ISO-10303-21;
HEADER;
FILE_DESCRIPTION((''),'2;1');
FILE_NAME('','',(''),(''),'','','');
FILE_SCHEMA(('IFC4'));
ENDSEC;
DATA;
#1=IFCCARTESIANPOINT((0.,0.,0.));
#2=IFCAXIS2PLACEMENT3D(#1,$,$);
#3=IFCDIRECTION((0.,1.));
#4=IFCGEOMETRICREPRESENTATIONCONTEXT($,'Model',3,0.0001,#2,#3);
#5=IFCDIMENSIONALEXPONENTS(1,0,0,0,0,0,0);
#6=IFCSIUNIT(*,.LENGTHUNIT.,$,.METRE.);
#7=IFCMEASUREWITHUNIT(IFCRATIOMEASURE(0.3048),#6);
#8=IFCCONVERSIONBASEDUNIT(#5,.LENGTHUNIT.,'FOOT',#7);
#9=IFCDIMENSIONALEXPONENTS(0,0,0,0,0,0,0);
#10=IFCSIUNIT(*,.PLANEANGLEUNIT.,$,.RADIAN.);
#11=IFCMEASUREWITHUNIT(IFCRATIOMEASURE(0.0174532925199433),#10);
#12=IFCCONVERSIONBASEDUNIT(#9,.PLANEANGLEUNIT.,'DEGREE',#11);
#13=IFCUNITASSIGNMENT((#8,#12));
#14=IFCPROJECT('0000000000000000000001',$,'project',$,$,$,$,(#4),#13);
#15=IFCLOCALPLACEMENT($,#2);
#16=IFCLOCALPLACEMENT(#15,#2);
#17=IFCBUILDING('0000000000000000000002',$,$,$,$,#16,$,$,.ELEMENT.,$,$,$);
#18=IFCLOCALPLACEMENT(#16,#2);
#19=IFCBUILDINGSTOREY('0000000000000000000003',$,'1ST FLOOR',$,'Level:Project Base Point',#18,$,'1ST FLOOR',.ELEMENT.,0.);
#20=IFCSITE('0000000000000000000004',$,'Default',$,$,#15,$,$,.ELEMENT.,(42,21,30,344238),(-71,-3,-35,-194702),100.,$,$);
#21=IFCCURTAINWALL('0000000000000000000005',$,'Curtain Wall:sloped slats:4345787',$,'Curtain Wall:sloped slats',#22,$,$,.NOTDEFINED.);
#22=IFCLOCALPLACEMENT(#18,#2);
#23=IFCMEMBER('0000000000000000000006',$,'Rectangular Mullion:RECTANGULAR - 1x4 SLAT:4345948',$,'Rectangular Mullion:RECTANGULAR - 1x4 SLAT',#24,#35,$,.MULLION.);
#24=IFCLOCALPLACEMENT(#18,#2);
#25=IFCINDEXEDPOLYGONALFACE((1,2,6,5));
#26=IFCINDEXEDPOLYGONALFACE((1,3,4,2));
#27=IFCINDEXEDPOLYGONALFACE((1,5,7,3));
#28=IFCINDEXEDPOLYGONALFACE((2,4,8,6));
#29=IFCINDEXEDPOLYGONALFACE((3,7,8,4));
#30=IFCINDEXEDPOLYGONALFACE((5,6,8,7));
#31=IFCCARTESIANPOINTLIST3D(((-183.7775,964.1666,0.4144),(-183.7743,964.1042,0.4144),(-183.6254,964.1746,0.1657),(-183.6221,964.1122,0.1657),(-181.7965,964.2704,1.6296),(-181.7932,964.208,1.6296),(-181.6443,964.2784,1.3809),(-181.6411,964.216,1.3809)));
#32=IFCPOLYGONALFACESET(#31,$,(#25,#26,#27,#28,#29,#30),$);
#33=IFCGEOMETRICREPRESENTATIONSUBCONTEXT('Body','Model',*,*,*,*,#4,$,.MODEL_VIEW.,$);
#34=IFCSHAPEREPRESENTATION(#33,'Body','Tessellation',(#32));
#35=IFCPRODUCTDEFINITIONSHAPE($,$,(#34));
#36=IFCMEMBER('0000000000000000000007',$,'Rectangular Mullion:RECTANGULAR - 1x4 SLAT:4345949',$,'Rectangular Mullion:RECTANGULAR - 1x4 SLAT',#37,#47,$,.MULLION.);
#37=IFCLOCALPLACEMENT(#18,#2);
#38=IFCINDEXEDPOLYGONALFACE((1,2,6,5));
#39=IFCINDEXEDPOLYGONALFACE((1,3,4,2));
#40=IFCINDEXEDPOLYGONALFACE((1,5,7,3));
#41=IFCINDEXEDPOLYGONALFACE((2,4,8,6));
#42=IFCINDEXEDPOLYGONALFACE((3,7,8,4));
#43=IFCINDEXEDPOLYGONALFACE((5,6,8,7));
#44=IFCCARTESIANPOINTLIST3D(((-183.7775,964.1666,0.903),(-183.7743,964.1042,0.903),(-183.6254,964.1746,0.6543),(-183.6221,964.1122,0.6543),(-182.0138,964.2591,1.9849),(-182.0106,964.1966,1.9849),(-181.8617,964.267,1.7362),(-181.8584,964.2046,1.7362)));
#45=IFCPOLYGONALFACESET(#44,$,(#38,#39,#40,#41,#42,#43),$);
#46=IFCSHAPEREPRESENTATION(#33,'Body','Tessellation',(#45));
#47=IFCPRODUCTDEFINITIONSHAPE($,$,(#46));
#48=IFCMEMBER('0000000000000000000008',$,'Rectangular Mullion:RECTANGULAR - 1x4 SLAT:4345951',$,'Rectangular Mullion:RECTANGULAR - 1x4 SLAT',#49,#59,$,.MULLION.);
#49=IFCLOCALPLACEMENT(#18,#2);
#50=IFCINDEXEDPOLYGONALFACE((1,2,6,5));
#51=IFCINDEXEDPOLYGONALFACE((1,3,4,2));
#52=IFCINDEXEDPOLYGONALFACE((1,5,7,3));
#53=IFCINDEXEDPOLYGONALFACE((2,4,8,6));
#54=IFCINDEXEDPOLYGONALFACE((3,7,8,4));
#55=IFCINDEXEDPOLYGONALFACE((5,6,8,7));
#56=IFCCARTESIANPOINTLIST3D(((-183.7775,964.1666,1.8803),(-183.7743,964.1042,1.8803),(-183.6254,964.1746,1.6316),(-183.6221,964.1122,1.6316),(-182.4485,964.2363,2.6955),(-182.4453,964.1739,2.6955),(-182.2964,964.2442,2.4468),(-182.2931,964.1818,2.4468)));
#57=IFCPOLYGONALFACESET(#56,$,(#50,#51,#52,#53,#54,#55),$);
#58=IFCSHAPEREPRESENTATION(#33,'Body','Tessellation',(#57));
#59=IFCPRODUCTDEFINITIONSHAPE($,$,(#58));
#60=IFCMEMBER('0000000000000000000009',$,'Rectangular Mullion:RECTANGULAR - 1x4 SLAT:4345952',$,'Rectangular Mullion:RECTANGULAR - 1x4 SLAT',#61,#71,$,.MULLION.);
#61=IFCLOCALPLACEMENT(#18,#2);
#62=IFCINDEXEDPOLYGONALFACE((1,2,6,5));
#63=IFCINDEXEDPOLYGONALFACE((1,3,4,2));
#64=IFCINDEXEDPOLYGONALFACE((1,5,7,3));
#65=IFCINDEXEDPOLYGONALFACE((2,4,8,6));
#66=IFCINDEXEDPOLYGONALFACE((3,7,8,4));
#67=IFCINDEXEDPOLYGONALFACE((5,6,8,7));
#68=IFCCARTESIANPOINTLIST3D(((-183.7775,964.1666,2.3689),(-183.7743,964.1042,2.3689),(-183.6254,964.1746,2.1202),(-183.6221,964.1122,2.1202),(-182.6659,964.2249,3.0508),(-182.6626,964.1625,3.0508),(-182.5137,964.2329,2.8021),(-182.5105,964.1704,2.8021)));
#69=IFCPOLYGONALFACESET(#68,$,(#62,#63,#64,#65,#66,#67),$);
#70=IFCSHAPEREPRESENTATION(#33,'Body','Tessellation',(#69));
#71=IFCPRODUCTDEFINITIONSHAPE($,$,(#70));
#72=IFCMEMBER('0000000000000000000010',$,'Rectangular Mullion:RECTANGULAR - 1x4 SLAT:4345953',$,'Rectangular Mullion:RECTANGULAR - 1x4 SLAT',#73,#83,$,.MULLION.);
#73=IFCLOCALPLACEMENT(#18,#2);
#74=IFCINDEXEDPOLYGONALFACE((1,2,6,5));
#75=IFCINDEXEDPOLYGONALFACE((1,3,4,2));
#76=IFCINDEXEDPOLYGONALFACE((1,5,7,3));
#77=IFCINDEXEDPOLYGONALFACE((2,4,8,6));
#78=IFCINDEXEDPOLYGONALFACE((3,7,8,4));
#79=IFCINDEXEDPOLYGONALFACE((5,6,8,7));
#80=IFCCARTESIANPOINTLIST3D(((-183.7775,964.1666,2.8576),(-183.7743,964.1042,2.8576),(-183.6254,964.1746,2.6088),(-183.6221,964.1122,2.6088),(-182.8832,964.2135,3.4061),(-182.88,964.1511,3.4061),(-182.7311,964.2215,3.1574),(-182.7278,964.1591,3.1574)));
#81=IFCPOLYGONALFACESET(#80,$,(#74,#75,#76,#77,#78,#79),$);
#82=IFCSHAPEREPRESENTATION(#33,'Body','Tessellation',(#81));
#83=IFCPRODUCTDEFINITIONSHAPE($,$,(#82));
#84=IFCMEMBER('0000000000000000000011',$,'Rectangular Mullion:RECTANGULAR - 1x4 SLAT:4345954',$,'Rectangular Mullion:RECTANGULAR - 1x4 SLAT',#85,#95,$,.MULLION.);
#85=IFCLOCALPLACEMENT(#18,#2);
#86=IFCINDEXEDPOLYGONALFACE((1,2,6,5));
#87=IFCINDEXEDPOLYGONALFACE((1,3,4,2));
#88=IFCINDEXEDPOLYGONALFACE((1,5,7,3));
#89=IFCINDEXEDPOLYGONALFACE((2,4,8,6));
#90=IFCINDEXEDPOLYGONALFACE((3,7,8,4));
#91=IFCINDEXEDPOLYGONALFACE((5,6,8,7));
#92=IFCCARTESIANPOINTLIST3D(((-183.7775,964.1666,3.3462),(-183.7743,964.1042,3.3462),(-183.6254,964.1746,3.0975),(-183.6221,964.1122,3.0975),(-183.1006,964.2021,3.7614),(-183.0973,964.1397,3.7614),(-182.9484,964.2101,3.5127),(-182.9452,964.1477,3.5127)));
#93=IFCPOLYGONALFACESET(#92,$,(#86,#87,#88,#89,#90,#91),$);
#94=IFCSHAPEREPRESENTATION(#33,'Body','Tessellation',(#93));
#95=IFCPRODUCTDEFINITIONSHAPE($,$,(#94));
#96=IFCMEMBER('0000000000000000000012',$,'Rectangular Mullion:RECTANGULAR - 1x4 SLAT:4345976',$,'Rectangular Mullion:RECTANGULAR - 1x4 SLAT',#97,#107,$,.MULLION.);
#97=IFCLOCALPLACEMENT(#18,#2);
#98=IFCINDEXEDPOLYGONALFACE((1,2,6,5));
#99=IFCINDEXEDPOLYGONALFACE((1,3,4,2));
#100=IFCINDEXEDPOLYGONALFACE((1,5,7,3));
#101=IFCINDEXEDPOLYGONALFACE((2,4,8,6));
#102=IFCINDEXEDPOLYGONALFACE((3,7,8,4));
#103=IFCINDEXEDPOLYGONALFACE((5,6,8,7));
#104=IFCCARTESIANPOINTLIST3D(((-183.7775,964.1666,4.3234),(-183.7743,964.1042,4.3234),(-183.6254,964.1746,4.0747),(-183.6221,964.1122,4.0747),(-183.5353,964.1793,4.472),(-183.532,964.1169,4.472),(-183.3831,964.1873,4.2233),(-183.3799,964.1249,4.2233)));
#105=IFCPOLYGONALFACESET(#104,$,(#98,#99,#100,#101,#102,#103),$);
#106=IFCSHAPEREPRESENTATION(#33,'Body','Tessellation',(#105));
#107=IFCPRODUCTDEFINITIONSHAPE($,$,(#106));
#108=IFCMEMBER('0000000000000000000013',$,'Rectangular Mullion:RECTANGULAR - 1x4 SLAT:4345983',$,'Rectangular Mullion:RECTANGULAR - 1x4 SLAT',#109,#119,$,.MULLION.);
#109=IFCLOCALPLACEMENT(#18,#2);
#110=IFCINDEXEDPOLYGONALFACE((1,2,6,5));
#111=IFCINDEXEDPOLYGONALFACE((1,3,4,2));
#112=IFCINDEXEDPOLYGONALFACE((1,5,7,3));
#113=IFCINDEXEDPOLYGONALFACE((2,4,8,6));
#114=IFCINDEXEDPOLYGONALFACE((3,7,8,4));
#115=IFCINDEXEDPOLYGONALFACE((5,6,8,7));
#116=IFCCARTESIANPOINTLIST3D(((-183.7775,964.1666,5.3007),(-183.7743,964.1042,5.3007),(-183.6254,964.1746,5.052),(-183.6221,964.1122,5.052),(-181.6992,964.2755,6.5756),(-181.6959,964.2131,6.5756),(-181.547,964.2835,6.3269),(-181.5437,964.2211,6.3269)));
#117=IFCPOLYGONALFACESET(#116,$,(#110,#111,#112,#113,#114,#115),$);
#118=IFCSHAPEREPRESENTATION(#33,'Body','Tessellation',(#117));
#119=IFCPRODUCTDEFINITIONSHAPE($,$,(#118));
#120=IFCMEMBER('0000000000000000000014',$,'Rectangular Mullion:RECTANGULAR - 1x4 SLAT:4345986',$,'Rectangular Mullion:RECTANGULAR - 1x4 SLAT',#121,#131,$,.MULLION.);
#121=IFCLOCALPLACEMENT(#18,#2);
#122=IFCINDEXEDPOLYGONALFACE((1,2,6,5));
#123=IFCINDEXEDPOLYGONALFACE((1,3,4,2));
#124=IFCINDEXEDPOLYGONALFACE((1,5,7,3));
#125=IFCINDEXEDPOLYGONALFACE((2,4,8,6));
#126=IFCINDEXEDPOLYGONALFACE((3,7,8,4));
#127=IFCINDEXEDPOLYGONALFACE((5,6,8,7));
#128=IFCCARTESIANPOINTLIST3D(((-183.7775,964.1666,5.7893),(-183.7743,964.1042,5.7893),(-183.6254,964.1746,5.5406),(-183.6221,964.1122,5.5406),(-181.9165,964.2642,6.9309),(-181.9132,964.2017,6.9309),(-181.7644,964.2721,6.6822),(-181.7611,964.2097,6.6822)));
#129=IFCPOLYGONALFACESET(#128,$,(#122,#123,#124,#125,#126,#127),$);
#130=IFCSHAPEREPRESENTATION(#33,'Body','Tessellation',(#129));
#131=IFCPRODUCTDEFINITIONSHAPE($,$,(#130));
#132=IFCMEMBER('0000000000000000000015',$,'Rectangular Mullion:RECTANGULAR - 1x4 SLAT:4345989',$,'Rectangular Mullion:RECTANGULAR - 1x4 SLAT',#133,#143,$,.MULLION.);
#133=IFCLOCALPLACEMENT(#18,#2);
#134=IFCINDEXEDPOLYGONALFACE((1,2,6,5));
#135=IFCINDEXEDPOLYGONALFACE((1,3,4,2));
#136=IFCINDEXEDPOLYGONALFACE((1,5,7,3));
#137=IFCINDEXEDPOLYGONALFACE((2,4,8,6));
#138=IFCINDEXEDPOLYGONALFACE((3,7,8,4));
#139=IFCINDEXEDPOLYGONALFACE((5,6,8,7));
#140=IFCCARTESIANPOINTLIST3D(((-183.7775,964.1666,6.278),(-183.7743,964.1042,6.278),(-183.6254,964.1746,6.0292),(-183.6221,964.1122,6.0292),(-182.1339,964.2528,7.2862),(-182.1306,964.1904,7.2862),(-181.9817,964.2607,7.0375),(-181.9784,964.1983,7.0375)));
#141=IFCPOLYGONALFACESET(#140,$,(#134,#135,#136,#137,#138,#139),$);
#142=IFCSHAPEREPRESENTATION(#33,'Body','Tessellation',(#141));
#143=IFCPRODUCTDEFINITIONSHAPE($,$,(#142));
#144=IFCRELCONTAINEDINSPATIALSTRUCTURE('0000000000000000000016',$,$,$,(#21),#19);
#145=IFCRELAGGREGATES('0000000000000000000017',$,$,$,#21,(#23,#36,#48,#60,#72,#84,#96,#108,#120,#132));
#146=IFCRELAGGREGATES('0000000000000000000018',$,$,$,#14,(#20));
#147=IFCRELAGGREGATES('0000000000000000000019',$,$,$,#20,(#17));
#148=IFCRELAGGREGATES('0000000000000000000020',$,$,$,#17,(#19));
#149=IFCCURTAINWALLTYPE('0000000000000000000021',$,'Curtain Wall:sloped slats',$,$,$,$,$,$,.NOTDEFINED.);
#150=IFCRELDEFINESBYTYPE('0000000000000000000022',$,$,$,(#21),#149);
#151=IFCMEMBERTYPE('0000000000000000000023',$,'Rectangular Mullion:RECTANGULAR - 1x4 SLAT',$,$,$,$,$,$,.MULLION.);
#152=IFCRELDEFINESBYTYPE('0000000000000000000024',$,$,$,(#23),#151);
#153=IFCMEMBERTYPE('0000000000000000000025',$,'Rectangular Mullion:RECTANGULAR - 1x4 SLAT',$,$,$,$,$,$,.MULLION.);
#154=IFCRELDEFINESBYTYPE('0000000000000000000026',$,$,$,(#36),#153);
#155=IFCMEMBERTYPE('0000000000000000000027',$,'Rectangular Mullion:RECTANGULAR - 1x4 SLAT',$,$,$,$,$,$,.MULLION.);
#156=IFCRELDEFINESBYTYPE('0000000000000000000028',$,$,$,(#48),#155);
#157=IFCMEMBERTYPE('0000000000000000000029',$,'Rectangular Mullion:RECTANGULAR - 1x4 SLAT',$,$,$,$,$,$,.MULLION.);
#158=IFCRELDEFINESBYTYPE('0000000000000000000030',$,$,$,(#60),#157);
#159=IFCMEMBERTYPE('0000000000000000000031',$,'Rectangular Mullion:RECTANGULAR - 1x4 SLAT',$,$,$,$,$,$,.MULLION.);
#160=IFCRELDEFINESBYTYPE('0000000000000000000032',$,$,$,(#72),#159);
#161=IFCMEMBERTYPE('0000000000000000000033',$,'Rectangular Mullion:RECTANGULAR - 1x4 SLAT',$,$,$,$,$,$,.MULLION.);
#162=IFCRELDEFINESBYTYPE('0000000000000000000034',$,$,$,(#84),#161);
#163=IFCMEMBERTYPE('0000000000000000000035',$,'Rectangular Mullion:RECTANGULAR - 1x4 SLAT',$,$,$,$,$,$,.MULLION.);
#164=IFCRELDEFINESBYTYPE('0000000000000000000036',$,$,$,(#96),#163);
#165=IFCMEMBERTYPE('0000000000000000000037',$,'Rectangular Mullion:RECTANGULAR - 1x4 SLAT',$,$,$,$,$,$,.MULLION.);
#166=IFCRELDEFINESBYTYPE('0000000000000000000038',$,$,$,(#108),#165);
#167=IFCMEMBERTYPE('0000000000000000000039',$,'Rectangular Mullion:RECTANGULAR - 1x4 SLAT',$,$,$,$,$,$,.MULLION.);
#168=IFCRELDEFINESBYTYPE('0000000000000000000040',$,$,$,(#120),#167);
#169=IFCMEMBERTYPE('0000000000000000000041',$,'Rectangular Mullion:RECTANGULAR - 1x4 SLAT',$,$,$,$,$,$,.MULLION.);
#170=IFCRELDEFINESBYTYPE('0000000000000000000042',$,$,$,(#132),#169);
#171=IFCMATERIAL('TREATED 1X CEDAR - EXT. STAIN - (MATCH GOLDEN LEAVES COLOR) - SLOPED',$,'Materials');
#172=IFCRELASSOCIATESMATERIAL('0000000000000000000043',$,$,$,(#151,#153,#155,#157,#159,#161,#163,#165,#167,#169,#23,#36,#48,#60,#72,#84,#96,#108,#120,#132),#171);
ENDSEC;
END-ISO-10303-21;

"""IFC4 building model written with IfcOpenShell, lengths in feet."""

from ifc_helpers import new_model, entity, si_unit, converted_unit, direction, frame, frame_2d, origin, origin_2d_with_axis, place, context, subcontext, project, spatial, rectangle, extrude, source, transform, mapped, material, material_profile, profile_set, profile_usage, type_object, type_shapes, element, aggregate, save


model = new_model("IFC4")

# Units and contexts
model_context = context("Model", 3, precision=0.0001, world=origin(), true_north=direction((0.0, 1.0)))
body_context = subcontext(model_context, "Body", "Model", "MODEL_VIEW")
ifc_project = project(units=[converted_unit("LENGTHUNIT", "FOOT", entity("IfcRatioMeasure", 0.3048), si_unit("LENGTHUNIT", "METRE"), dimensions=[1, 0, 0, 0, 0, 0, 0]), converted_unit("PLANEANGLEUNIT", "DEGREE", entity("IfcRatioMeasure", 0.0174532925199433), si_unit("PLANEANGLEUNIT", "RADIAN"), dimensions=[0, 0, 0, 0, 0, 0, 0])], contexts=[model_context])

# Site, building, storey
site_placement = place(None, origin())
site = spatial("IfcSite", under=ifc_project, at=site_placement, Name="Default", CompositionType="ELEMENT", RefLatitude=(42, 21, 30, 344238), RefLongitude=(-71, -3, -35, -194702), RefElevation=100.0)
building_placement = place(site_placement, origin())
building = spatial("IfcBuilding", under=site, at=building_placement, CompositionType="ELEMENT")
storey_placement = place(building_placement, origin())
storey = spatial("IfcBuildingStorey", under=building, at=storey_placement, Name="1ST FLOOR", ObjectType="Level:Project Base Point", LongName="1ST FLOOR", CompositionType="ELEMENT", Elevation=0.0)

# Curtain wall
curtain_wall_type_1 = type_object("IfcCurtainWallType", Name="Curtain Wall:sloped slats", PredefinedType="NOTDEFINED")
curtain_wall_1_placement = place(storey_placement, origin())
curtain_wall_1 = element("IfcCurtainWall", 1, at=curtain_wall_1_placement, inside=storey, type_object=curtain_wall_type_1, Name="Curtain Wall:sloped slats:4345787", ObjectType="Curtain Wall:sloped slats", PredefinedType="NOTDEFINED")
ifc_material_1 = material(Name="TREATED 1X CEDAR - EXT. STAIN - (MATCH GOLDEN LEAVES COLOR) - SLOPED", Category="Materials")
ifc_material_profile_1 = material_profile(ifc_material_1, rectangle(XDim=0.0625, YDim=0.2917, at=frame_2d((0.0, 0.0), x_axis=(1.0, 0.0))), Name="RECTANGULAR - 1x4 SLAT")
ifc_profile_set_1 = profile_set([ifc_material_profile_1], Name="RECTANGULAR - 1x4 SLAT")

# Members
ifc_profile_usage_1 = profile_usage(ifc_profile_set_1)
member_type_1 = type_object("IfcMemberType", Name="Rectangular Mullion:RECTANGULAR - 1x4 SLAT", PredefinedType="MULLION", material=ifc_profile_set_1)
shared_shape_1 = source(origin(), body_context, "Body", "SweptSolid", [
    extrude(rectangle(XDim=0.0625, YDim=0.2917, at=frame_2d((0.0, 0.0), x_axis=(1.0, 0.0))), frame((0.0, 0.0, -2.3264), z_axis=(0.0, 0.0, 1.0), x_axis=(0.0, -1.0, 0.0)), (0.0, 0.0, 1.0), 2.3264),
])
type_shapes(member_type_1, [shared_shape_1])
member_1_placement = place(storey_placement, frame((-183.6998, 964.1394, 0.2901), z_axis=(-0.851559, -0.044628, -0.522356), x_axis=(-0.52164, -0.027338, 0.852727)))
member_1 = element("IfcMember", 2, at=member_1_placement, type_object=member_type_1, material=ifc_profile_usage_1, Name="Rectangular Mullion:RECTANGULAR - 1x4 SLAT:4345948", ObjectType="Rectangular Mullion:RECTANGULAR - 1x4 SLAT", PredefinedType="MULLION", context=body_context, shape_type="MappedRepresentation", body=[
    mapped(shared_shape_1, transform((0.0, 0.0, 0.0), scale=1.0)),
])
ifc_profile_usage_2 = profile_usage(ifc_profile_set_1)
member_type_2 = type_object("IfcMemberType", Name="Rectangular Mullion:RECTANGULAR - 1x4 SLAT", PredefinedType="MULLION", material=ifc_profile_set_1)
shared_shape_2 = source(origin(), body_context, "Body", "SweptSolid", [
    extrude(rectangle(XDim=0.0625, YDim=0.2917, at=frame_2d((0.0, 0.0), x_axis=(1.0, 0.0))), frame((0.0, 0.0, -2.0711), z_axis=(0.0, 0.0, 1.0), x_axis=(0.0, -1.0, 0.0)), (0.0, 0.0, 1.0), 2.0711),
])
type_shapes(member_type_2, [shared_shape_2])
member_2_placement = place(storey_placement, frame((-183.6998, 964.1394, 0.7787), z_axis=(-0.851559, -0.044628, -0.522356), x_axis=(-0.52164, -0.027338, 0.852727)))
member_2 = element("IfcMember", 3, at=member_2_placement, type_object=member_type_2, material=ifc_profile_usage_2, Name="Rectangular Mullion:RECTANGULAR - 1x4 SLAT:4345949", ObjectType="Rectangular Mullion:RECTANGULAR - 1x4 SLAT", PredefinedType="MULLION", context=body_context, shape_type="MappedRepresentation", body=[
    mapped(shared_shape_2, transform((0.0, 0.0, 0.0), scale=1.0)),
])
ifc_profile_usage_3 = profile_usage(ifc_profile_set_1)
member_type_3 = type_object("IfcMemberType", Name="Rectangular Mullion:RECTANGULAR - 1x4 SLAT", PredefinedType="MULLION", material=ifc_profile_set_1)
shared_shape_3 = source(origin(), body_context, "Body", "SweptSolid", [
    extrude(rectangle(XDim=0.0625, YDim=0.2917, at=origin_2d_with_axis()), frame((0.0, 0.0, -1.5607), z_axis=(0.0, 0.0, 1.0), x_axis=(0.0, -1.0, 0.0)), (0.0, 0.0, 1.0), 1.5607),
])
type_shapes(member_type_3, [shared_shape_3])
member_3_placement = place(storey_placement, frame((-183.6998, 964.1394, 1.7559), z_axis=(-0.851559, -0.044628, -0.522356), x_axis=(-0.52164, -0.027338, 0.852727)))
member_3 = element("IfcMember", 4, at=member_3_placement, type_object=member_type_3, material=ifc_profile_usage_3, Name="Rectangular Mullion:RECTANGULAR - 1x4 SLAT:4345951", ObjectType="Rectangular Mullion:RECTANGULAR - 1x4 SLAT", PredefinedType="MULLION", context=body_context, shape_type="MappedRepresentation", body=[
    mapped(shared_shape_3, transform((0.0, 0.0, 0.0), scale=1.0)),
])
ifc_profile_usage_4 = profile_usage(ifc_profile_set_1)
member_type_4 = type_object("IfcMemberType", Name="Rectangular Mullion:RECTANGULAR - 1x4 SLAT", PredefinedType="MULLION", material=ifc_profile_set_1)
shared_shape_4 = source(origin(), body_context, "Body", "SweptSolid", [
    extrude(rectangle(XDim=0.0625, YDim=0.2917, at=frame_2d((0.0, 0.0), x_axis=(1.0, 0.0))), frame((0.0, 0.0, -1.3054), z_axis=(0.0, 0.0, 1.0), x_axis=(0.0, -1.0, 0.0)), (0.0, 0.0, 1.0), 1.3054),
])
type_shapes(member_type_4, [shared_shape_4])
member_4_placement = place(storey_placement, frame((-183.6998, 964.1394, 2.2446), z_axis=(-0.851559, -0.044628, -0.522356), x_axis=(-0.52164, -0.027338, 0.852727)))
member_4 = element("IfcMember", 5, at=member_4_placement, type_object=member_type_4, material=ifc_profile_usage_4, Name="Rectangular Mullion:RECTANGULAR - 1x4 SLAT:4345952", ObjectType="Rectangular Mullion:RECTANGULAR - 1x4 SLAT", PredefinedType="MULLION", context=body_context, shape_type="MappedRepresentation", body=[
    mapped(shared_shape_4, transform((0.0, 0.0, 0.0), scale=1.0)),
])
ifc_profile_usage_5 = profile_usage(ifc_profile_set_1)
member_type_5 = type_object("IfcMemberType", Name="Rectangular Mullion:RECTANGULAR - 1x4 SLAT", PredefinedType="MULLION", material=ifc_profile_set_1)
shared_shape_5 = source(origin(), body_context, "Body", "SweptSolid", [
    extrude(rectangle(XDim=0.0625, YDim=0.2917, at=frame_2d((0.0, 0.0), x_axis=(1.0, 0.0))), frame((0.0, 0.0, -1.0502), z_axis=(0.0, 0.0, 1.0), x_axis=(0.0, -1.0, 0.0)), (0.0, 0.0, 1.0), 1.0502),
])
type_shapes(member_type_5, [shared_shape_5])
member_5_placement = place(storey_placement, frame((-183.6998, 964.1394, 2.7332), z_axis=(-0.851559, -0.044628, -0.522356), x_axis=(-0.52164, -0.027338, 0.852727)))
member_5 = element("IfcMember", 6, at=member_5_placement, type_object=member_type_5, material=ifc_profile_usage_5, Name="Rectangular Mullion:RECTANGULAR - 1x4 SLAT:4345953", ObjectType="Rectangular Mullion:RECTANGULAR - 1x4 SLAT", PredefinedType="MULLION", context=body_context, shape_type="MappedRepresentation", body=[
    mapped(shared_shape_5, transform((0.0, 0.0, 0.0), scale=1.0)),
])
ifc_profile_usage_6 = profile_usage(ifc_profile_set_1)
member_type_6 = type_object("IfcMemberType", Name="Rectangular Mullion:RECTANGULAR - 1x4 SLAT", PredefinedType="MULLION", material=ifc_profile_set_1)
shared_shape_6 = source(origin(), body_context, "Body", "SweptSolid", [
    extrude(rectangle(XDim=0.0625, YDim=0.2917, at=frame_2d((0.0, 0.0), x_axis=(1.0, 0.0))), frame((0.0, 0.0, -0.7949), z_axis=(0.0, 0.0, 1.0), x_axis=(0.0, -1.0, 0.0)), (0.0, 0.0, 1.0), 0.7949),
])
type_shapes(member_type_6, [shared_shape_6])
member_6_placement = place(storey_placement, frame((-183.6998, 964.1394, 3.2218), z_axis=(-0.851559, -0.044628, -0.522356), x_axis=(-0.52164, -0.027338, 0.852727)))
member_6 = element("IfcMember", 7, at=member_6_placement, type_object=member_type_6, material=ifc_profile_usage_6, Name="Rectangular Mullion:RECTANGULAR - 1x4 SLAT:4345954", ObjectType="Rectangular Mullion:RECTANGULAR - 1x4 SLAT", PredefinedType="MULLION", context=body_context, shape_type="MappedRepresentation", body=[
    mapped(shared_shape_6, transform((0.0, 0.0, 0.0), scale=1.0)),
])
ifc_profile_usage_7 = profile_usage(ifc_profile_set_1)
member_type_7 = type_object("IfcMemberType", Name="Rectangular Mullion:RECTANGULAR - 1x4 SLAT", PredefinedType="MULLION", material=ifc_profile_set_1)
shared_shape_7 = source(origin(), body_context, "Body", "SweptSolid", [
    extrude(rectangle(XDim=0.0625, YDim=0.2917, at=frame_2d((0.0, 0.0), x_axis=(1.0, 0.0))), frame((0.0, 0.0, -0.2845), z_axis=(0.0, 0.0, 1.0), x_axis=(0.0, -1.0, 0.0)), (0.0, 0.0, 1.0), 0.2845),
])
type_shapes(member_type_7, [shared_shape_7])
member_7_placement = place(storey_placement, frame((-183.6998, 964.1394, 4.1991), z_axis=(-0.851559, -0.044628, -0.522356), x_axis=(-0.52164, -0.027338, 0.852727)))
member_7 = element("IfcMember", 8, at=member_7_placement, type_object=member_type_7, material=ifc_profile_usage_7, Name="Rectangular Mullion:RECTANGULAR - 1x4 SLAT:4345976", ObjectType="Rectangular Mullion:RECTANGULAR - 1x4 SLAT", PredefinedType="MULLION", context=body_context, shape_type="MappedRepresentation", body=[
    mapped(shared_shape_7, transform((0.0, 0.0, 0.0), scale=1.0)),
])
ifc_profile_usage_8 = profile_usage(ifc_profile_set_1)
member_type_8 = type_object("IfcMemberType", Name="Rectangular Mullion:RECTANGULAR - 1x4 SLAT", PredefinedType="MULLION", material=ifc_profile_set_1)
shared_shape_8 = source(origin(), body_context, "Body", "SweptSolid", [
    extrude(rectangle(XDim=0.0625, YDim=0.2917, at=frame_2d((0.0, 0.0), x_axis=(1.0, 0.0))), frame((0.0, 0.0, -2.4407), z_axis=(0.0, 0.0, 1.0), x_axis=(0.0, -1.0, 0.0)), (0.0, 0.0, 1.0), 2.4407),
])
type_shapes(member_type_8, [shared_shape_8])
member_8_placement = place(storey_placement, frame((-183.6998, 964.1394, 5.1763), z_axis=(-0.851559, -0.044628, -0.522356), x_axis=(-0.52164, -0.027338, 0.852727)))
member_8 = element("IfcMember", 9, at=member_8_placement, type_object=member_type_8, material=ifc_profile_usage_8, Name="Rectangular Mullion:RECTANGULAR - 1x4 SLAT:4345983", ObjectType="Rectangular Mullion:RECTANGULAR - 1x4 SLAT", PredefinedType="MULLION", context=body_context, shape_type="MappedRepresentation", body=[
    mapped(shared_shape_8, transform((0.0, 0.0, 0.0), scale=1.0)),
])
ifc_profile_usage_9 = profile_usage(ifc_profile_set_1)
member_type_9 = type_object("IfcMemberType", Name="Rectangular Mullion:RECTANGULAR - 1x4 SLAT", PredefinedType="MULLION", material=ifc_profile_set_1)
shared_shape_9 = source(origin(), body_context, "Body", "SweptSolid", [
    extrude(rectangle(XDim=0.0625, YDim=0.2917, at=origin_2d_with_axis()), frame((0.0, 0.0, -2.1854), z_axis=(0.0, 0.0, 1.0), x_axis=(0.0, -1.0, 0.0)), (0.0, 0.0, 1.0), 2.1854),
])
type_shapes(member_type_9, [shared_shape_9])
member_9_placement = place(storey_placement, frame((-183.6998, 964.1394, 5.665), z_axis=(-0.851559, -0.044628, -0.522356), x_axis=(-0.52164, -0.027338, 0.852727)))
member_9 = element("IfcMember", 10, at=member_9_placement, type_object=member_type_9, material=ifc_profile_usage_9, Name="Rectangular Mullion:RECTANGULAR - 1x4 SLAT:4345986", ObjectType="Rectangular Mullion:RECTANGULAR - 1x4 SLAT", PredefinedType="MULLION", context=body_context, shape_type="MappedRepresentation", body=[
    mapped(shared_shape_9, transform((0.0, 0.0, 0.0), scale=1.0)),
])
ifc_profile_usage_10 = profile_usage(ifc_profile_set_1)
member_type_10 = type_object("IfcMemberType", Name="Rectangular Mullion:RECTANGULAR - 1x4 SLAT", PredefinedType="MULLION", material=ifc_profile_set_1)
shared_shape_10 = source(origin(), body_context, "Body", "SweptSolid", [
    extrude(rectangle(XDim=0.0625, YDim=0.2917, at=origin_2d_with_axis()), frame((0.0, 0.0, -1.9302), z_axis=(0.0, 0.0, 1.0), x_axis=(0.0, -1.0, 0.0)), (0.0, 0.0, 1.0), 1.9302),
])
type_shapes(member_type_10, [shared_shape_10])
member_10_placement = place(storey_placement, frame((-183.6998, 964.1394, 6.1536), z_axis=(-0.851559, -0.044628, -0.522356), x_axis=(-0.52164, -0.027338, 0.852727)))
member_10 = element("IfcMember", 11, at=member_10_placement, type_object=member_type_10, material=ifc_profile_usage_10, Name="Rectangular Mullion:RECTANGULAR - 1x4 SLAT:4345989", ObjectType="Rectangular Mullion:RECTANGULAR - 1x4 SLAT", PredefinedType="MULLION", context=body_context, shape_type="MappedRepresentation", body=[
    mapped(shared_shape_10, transform((0.0, 0.0, 0.0), scale=1.0)),
])
aggregate(curtain_wall_1, [member_1, member_2, member_3, member_4, member_5, member_6, member_7, member_8, member_9, member_10])

save(model, "model.ifc")
